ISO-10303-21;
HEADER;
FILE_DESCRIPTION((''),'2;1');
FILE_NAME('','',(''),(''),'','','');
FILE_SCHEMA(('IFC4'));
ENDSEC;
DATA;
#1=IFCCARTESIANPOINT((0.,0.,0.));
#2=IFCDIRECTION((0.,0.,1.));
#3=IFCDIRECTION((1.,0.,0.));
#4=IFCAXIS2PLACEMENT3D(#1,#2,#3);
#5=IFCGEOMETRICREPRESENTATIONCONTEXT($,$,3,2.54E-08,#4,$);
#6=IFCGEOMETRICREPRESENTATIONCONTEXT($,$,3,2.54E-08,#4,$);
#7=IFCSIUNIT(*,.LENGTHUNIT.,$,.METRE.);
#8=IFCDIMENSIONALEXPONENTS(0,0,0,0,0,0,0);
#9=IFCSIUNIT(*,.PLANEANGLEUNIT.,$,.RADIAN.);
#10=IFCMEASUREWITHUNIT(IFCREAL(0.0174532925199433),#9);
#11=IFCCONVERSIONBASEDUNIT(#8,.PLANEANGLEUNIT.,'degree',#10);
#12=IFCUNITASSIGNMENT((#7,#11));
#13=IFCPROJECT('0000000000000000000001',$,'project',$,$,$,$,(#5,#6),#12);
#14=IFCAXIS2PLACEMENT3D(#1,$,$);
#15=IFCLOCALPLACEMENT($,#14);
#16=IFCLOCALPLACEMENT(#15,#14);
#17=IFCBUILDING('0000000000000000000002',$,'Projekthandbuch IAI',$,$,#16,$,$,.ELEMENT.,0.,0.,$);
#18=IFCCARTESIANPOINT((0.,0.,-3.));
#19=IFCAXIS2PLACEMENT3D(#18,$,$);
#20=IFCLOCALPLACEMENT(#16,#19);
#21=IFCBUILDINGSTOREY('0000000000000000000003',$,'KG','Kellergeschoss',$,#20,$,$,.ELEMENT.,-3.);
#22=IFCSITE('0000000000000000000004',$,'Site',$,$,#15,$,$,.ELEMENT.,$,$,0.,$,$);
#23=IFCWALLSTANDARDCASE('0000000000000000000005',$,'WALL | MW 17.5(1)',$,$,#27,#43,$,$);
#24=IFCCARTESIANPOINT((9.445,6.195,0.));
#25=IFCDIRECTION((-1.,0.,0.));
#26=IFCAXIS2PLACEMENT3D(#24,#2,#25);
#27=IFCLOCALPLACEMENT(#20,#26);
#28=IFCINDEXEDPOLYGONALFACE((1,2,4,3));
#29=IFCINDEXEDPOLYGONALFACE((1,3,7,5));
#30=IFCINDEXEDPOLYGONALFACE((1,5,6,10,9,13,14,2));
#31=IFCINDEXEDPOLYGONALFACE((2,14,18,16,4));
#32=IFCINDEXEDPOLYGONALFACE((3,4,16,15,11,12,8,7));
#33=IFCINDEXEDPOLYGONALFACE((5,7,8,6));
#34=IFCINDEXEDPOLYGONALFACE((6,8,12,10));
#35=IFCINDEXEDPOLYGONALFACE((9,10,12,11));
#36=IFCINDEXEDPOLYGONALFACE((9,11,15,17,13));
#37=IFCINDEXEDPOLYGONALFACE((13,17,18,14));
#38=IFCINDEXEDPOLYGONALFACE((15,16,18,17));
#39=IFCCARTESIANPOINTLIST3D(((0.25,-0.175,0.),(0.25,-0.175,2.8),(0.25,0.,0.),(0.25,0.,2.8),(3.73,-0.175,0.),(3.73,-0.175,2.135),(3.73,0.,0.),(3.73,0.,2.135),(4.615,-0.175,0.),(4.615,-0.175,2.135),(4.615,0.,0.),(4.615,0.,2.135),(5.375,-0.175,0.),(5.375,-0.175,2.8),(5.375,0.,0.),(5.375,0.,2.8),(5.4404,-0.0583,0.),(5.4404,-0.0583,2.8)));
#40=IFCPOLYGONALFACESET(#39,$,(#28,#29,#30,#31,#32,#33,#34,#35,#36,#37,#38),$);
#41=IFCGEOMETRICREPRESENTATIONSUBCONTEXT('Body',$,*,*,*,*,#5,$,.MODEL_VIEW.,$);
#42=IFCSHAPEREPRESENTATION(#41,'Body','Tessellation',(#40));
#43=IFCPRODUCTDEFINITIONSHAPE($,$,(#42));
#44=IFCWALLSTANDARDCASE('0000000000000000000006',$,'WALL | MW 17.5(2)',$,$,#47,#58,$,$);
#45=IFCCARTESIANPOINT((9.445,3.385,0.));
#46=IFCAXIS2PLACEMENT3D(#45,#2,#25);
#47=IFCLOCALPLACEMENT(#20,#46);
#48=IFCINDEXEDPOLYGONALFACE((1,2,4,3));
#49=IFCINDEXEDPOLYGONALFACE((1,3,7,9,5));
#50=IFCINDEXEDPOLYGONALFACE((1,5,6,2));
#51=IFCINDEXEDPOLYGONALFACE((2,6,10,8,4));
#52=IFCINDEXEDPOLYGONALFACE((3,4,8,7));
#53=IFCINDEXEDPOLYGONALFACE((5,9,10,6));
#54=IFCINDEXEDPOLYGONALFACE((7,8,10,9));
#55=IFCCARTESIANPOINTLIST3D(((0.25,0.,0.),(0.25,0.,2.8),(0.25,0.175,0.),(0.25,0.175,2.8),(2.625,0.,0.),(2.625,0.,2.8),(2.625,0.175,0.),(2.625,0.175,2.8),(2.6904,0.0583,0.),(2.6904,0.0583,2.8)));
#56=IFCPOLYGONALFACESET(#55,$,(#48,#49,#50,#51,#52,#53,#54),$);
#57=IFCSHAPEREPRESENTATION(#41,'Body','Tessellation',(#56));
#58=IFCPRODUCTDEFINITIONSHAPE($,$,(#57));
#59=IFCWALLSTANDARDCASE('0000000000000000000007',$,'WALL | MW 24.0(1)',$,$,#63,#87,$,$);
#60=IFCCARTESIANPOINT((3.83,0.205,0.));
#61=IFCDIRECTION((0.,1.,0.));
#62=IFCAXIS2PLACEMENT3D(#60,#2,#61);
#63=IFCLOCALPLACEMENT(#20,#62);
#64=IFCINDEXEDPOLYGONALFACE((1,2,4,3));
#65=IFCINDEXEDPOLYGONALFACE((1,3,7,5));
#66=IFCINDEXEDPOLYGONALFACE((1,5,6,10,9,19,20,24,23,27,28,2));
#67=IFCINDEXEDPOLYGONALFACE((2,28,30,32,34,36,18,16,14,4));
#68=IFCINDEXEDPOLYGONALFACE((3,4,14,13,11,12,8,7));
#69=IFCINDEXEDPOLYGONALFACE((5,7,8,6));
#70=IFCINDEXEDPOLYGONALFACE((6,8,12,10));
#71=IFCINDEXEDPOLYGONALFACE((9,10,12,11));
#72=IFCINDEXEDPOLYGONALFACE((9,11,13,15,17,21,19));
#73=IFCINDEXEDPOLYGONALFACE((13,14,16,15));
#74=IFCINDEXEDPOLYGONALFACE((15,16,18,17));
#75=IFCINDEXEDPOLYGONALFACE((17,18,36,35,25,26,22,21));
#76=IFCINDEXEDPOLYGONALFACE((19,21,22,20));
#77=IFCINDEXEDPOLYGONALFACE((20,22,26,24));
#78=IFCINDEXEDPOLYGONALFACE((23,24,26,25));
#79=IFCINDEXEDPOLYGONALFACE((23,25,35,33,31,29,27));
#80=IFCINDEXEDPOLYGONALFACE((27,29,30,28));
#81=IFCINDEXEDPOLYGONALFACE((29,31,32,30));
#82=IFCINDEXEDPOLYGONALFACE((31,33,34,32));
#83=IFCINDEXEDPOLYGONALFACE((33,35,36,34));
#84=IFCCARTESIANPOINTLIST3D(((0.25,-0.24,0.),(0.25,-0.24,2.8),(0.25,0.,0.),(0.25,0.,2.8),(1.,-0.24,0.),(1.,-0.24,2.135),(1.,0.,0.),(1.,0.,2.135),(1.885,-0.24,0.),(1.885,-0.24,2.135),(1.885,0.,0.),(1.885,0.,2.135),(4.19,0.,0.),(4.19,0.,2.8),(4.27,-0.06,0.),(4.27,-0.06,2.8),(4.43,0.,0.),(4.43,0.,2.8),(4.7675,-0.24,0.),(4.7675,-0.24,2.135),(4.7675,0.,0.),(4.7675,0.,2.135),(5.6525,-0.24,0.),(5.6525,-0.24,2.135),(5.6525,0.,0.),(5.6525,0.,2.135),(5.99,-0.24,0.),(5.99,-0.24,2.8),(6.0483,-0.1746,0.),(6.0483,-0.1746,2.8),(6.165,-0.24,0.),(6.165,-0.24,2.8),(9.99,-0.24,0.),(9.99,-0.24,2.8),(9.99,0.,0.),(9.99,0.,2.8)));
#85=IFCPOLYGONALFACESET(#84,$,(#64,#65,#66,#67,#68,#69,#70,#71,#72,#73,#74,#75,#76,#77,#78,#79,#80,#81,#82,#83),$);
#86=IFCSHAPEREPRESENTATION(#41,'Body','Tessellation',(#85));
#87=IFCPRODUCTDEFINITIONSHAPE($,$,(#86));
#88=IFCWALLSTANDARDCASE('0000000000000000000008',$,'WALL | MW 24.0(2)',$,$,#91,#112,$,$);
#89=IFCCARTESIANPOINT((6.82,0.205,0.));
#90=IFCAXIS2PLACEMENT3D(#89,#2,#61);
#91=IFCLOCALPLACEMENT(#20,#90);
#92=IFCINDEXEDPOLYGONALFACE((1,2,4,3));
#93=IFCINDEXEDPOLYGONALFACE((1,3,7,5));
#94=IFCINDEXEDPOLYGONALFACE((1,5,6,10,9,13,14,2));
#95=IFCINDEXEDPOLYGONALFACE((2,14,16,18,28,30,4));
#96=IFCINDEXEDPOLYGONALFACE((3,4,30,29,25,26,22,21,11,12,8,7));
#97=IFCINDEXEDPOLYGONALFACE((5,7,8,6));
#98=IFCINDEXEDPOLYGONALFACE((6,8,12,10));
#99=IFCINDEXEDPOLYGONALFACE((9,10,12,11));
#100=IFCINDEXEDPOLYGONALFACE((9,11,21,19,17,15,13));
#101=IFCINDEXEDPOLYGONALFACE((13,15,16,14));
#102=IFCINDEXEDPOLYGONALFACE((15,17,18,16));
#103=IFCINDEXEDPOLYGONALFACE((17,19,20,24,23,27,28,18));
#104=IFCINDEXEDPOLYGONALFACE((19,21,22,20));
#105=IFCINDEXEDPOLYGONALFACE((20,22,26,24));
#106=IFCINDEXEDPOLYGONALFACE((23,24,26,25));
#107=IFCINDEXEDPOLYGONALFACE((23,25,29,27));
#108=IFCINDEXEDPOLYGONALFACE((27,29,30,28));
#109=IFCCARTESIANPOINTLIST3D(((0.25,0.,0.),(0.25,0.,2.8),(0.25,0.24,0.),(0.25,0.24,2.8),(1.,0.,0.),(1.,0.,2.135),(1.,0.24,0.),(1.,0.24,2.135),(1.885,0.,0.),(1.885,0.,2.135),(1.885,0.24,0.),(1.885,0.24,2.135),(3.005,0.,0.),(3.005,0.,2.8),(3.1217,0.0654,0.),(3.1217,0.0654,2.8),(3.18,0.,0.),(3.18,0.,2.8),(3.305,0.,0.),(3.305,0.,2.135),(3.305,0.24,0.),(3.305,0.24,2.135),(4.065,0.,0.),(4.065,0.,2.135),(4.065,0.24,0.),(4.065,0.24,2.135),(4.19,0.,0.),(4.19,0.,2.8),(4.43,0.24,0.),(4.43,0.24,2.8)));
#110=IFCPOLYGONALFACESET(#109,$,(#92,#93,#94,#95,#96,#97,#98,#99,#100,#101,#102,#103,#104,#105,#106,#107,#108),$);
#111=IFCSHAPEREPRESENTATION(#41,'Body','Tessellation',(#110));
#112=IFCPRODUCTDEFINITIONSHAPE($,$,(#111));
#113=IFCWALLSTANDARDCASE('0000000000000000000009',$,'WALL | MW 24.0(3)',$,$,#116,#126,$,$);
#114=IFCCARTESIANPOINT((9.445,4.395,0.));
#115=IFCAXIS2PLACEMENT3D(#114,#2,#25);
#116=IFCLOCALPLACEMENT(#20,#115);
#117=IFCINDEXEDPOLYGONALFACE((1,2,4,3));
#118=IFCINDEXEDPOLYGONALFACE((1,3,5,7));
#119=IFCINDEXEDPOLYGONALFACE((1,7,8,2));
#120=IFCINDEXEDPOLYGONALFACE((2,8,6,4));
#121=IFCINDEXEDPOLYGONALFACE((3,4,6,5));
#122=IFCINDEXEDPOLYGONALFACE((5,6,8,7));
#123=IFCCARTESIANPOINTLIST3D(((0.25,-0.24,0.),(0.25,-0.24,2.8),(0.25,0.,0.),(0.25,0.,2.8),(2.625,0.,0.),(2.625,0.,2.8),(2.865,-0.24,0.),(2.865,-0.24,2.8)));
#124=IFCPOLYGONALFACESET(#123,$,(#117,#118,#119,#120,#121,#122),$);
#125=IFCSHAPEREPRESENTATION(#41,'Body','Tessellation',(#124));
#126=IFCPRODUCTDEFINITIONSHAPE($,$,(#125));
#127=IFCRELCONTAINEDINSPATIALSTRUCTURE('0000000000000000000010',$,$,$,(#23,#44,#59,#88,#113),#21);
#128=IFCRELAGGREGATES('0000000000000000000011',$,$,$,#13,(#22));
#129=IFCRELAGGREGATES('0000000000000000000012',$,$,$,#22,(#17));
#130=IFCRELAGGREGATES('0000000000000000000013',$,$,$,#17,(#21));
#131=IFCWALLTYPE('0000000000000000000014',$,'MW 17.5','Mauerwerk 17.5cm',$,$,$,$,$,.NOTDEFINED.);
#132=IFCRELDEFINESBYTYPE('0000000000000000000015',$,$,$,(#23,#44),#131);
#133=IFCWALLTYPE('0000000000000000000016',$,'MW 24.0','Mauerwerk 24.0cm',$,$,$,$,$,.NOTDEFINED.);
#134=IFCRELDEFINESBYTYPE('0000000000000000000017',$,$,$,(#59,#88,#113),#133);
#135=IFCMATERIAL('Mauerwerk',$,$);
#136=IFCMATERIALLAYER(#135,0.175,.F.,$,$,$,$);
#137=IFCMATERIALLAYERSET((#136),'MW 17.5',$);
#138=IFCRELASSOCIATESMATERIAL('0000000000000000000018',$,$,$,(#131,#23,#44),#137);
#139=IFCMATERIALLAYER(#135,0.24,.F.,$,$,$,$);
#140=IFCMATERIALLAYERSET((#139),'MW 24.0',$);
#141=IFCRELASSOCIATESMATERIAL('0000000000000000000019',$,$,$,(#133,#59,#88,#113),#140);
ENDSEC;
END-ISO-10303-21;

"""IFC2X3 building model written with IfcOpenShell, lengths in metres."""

from ifc_helpers import new_model, entity, si_unit, converted_unit, frame, origin, origin_with_axes, origin_2d_with_axis, place, context, subcontext, project, spatial, polyline, segment, composite_curve, rectangle, outline, extrude, material, layer, layer_set, layer_usage, type_object, element, save


model = new_model("IFC2X3")

# Units and contexts
context_of_model_1 = context(None, 3, precision=2.54e-08, world=origin_with_axes())
context_of_model_2 = context(None, 3, precision=2.54e-08, world=origin_with_axes())
body_context = subcontext(context_of_model_1, "Body", None, "MODEL_VIEW")
ifc_project = project(units=[si_unit("LENGTHUNIT", "METRE"), converted_unit("PLANEANGLEUNIT", "degree", entity("IfcReal", 0.0174532925199433), si_unit("PLANEANGLEUNIT", "RADIAN"), dimensions=[0, 0, 0, 0, 0, 0, 0])], contexts=[context_of_model_1, context_of_model_2])

# Site, building, storey
site_placement = place(None, origin())
site = spatial("IfcSite", under=ifc_project, at=site_placement, Name="Site", CompositionType="ELEMENT", RefElevation=0.0)
building_placement = place(site_placement, origin())
building = spatial("IfcBuilding", under=site, at=building_placement, Name="Projekthandbuch IAI", CompositionType="ELEMENT", ElevationOfRefHeight=0.0, ElevationOfTerrain=0.0)
storey_placement = place(building_placement, frame((0.0, 0.0, -3.0)))
storey = spatial("IfcBuildingStorey", under=building, at=storey_placement, Name="KG", Description="Kellergeschoss", CompositionType="ELEMENT", Elevation=-3.0)

# Wall, opening
ifc_material_1 = material(Name="Mauerwerk")
ifc_layer_1 = layer(ifc_material_1, 0.175, ventilated=False)
ifc_layer_set_1 = layer_set([ifc_layer_1], Name="MW 17.5")
ifc_layer_usage_1 = layer_usage(ifc_layer_set_1, "AXIS2", "POSITIVE", -0.175)
wall_type_1 = type_object("IfcWallType", Name="MW 17.5", Description="Mauerwerk 17.5cm", PredefinedType="NOTDEFINED", material=ifc_layer_set_1)
wall_1_placement = place(storey_placement, frame((9.445, 6.195, 0.0), z_axis=(0.0, 0.0, 1.0), x_axis=(-1.0, 0.0, 0.0)))
wall_1 = element("IfcWallStandardCase", 1, at=wall_1_placement, inside=storey, type_object=wall_type_1, material=ifc_layer_usage_1, Name="WALL | MW 17.5(1)", context=body_context, shape_type="SweptSolid", held_by="IfcProductRepresentation", body=[
    extrude(outline(composite_curve([segment(polyline([(5.375, -0.175), (5.4404, -0.0583)]), True, "CONTINUOUS"), segment(polyline([(5.4404, -0.0583), (5.375, 0.0)]), True, "CONTINUOUS"), segment(polyline([(5.375, 0.0), (0.25, 0.0)]), True, "CONTINUOUS"), segment(polyline([(0.25, 0.0), (0.25, -0.175)]), True, "CONTINUOUS"), segment(polyline([(0.25, -0.175), (5.375, -0.175)]), True, "CONTINUOUS")], self_intersect=False)), origin(), (0.0, 0.0, 1.0), 2.8),
])
opening_1_placement = place(wall_1_placement, frame((3.73, -0.0875, 0.0)))
element("IfcOpeningElement", 2, at=opening_1_placement, cuts=wall_1, context=body_context, shape_type="SweptSolid", held_by="IfcProductRepresentation", body=[
    extrude(rectangle(XDim=0.885, YDim=2.135, at=origin_2d_with_axis()), frame((0.4425, 0.0875, 1.0675), z_axis=(0.0, -1.0, 0.0), x_axis=(1.0, 0.0, 0.0)), (0.0, 0.0, 1.0), 0.175),
])

# Wall
ifc_layer_usage_2 = layer_usage(ifc_layer_set_1, "AXIS2", "POSITIVE", 0.0)
wall_2_placement = place(storey_placement, frame((9.445, 3.385, 0.0), z_axis=(0.0, 0.0, 1.0), x_axis=(-1.0, 0.0, 0.0)))
element("IfcWallStandardCase", 3, at=wall_2_placement, inside=storey, type_object=wall_type_1, material=ifc_layer_usage_2, Name="WALL | MW 17.5(2)", context=body_context, shape_type="SweptSolid", held_by="IfcProductRepresentation", body=[
    extrude(outline(composite_curve([segment(polyline([(2.625, 0.0), (2.6904, 0.0583)]), True, "CONTINUOUS"), segment(polyline([(2.6904, 0.0583), (2.625, 0.175)]), True, "CONTINUOUS"), segment(polyline([(2.625, 0.175), (0.25, 0.175)]), True, "CONTINUOUS"), segment(polyline([(0.25, 0.175), (0.25, 0.0)]), True, "CONTINUOUS"), segment(polyline([(0.25, 0.0), (2.625, 0.0)]), True, "CONTINUOUS")], self_intersect=False)), origin(), (0.0, 0.0, 1.0), 2.8),
])

# Walls, openings
ifc_layer_2 = layer(ifc_material_1, 0.24, ventilated=False)
ifc_layer_set_2 = layer_set([ifc_layer_2], Name="MW 24.0")
ifc_layer_usage_3 = layer_usage(ifc_layer_set_2, "AXIS2", "POSITIVE", -0.24)
wall_type_2 = type_object("IfcWallType", Name="MW 24.0", Description="Mauerwerk 24.0cm", PredefinedType="NOTDEFINED", material=ifc_layer_set_2)
wall_3_placement = place(storey_placement, frame((3.83, 0.205, 0.0), z_axis=(0.0, 0.0, 1.0), x_axis=(0.0, 1.0, 0.0)))
wall_3 = element("IfcWallStandardCase", 4, at=wall_3_placement, inside=storey, type_object=wall_type_2, material=ifc_layer_usage_3, Name="WALL | MW 24.0(1)", context=body_context, shape_type="SweptSolid", held_by="IfcProductRepresentation", body=[
    extrude(outline(composite_curve([segment(polyline([(6.0483, -0.1746), (6.165, -0.24)]), True, "CONTINUOUS"), segment(polyline([(6.165, -0.24), (9.99, -0.24)]), True, "CONTINUOUS"), segment(polyline([(9.99, -0.24), (9.99, 0.0)]), True, "CONTINUOUS"), segment(polyline([(9.99, 0.0), (5.99, 0.0)]), True, "CONTINUOUS"), segment(polyline([(5.99, 0.0), (4.43, 0.0)]), True, "CONTINUOUS"), segment(polyline([(4.43, 0.0), (4.27, -0.06)]), True, "CONTINUOUS"), segment(polyline([(4.27, -0.06), (4.19, 0.0)]), True, "CONTINUOUS"), segment(polyline([(4.19, 0.0), (0.25, 0.0)]), True, "CONTINUOUS"), segment(polyline([(0.25, 0.0), (0.25, -0.24)]), True, "CONTINUOUS"), segment(polyline([(0.25, -0.24), (4.19, -0.24)]), True, "CONTINUOUS"), segment(polyline([(4.19, -0.24), (5.99, -0.24)]), True, "CONTINUOUS"), segment(polyline([(5.99, -0.24), (6.0483, -0.1746)]), True, "CONTINUOUS")], self_intersect=False)), origin(), (0.0, 0.0, 1.0), 2.8),
])
opening_2_placement = place(wall_3_placement, frame((1.0, -0.12, 0.0)))
element("IfcOpeningElement", 5, at=opening_2_placement, cuts=wall_3, context=body_context, shape_type="SweptSolid", held_by="IfcProductRepresentation", body=[
    extrude(rectangle(XDim=0.885, YDim=2.135, at=origin_2d_with_axis()), frame((0.4425, 0.12, 1.0675), z_axis=(0.0, -1.0, 0.0), x_axis=(1.0, 0.0, 0.0)), (0.0, 0.0, 1.0), 0.24),
])
opening_3_placement = place(wall_3_placement, frame((4.7675, -0.12, 0.0)))
element("IfcOpeningElement", 6, at=opening_3_placement, cuts=wall_3, context=body_context, shape_type="SweptSolid", held_by="IfcProductRepresentation", body=[
    extrude(rectangle(XDim=0.885, YDim=2.135, at=origin_2d_with_axis()), frame((0.4425, 0.12, 1.0675), z_axis=(0.0, -1.0, 0.0), x_axis=(1.0, 0.0, 0.0)), (0.0, 0.0, 1.0), 0.24),
])
ifc_layer_usage_4 = layer_usage(ifc_layer_set_2, "AXIS2", "POSITIVE", 0.0)
wall_4_placement = place(storey_placement, frame((6.82, 0.205, 0.0), z_axis=(0.0, 0.0, 1.0), x_axis=(0.0, 1.0, 0.0)))
wall_4 = element("IfcWallStandardCase", 7, at=wall_4_placement, inside=storey, type_object=wall_type_2, material=ifc_layer_usage_4, Name="WALL | MW 24.0(2)", context=body_context, shape_type="SweptSolid", held_by="IfcProductRepresentation", body=[
    extrude(outline(composite_curve([segment(polyline([(3.005, 0.0), (3.1217, 0.0654)]), True, "CONTINUOUS"), segment(polyline([(3.1217, 0.0654), (3.18, 0.0)]), True, "CONTINUOUS"), segment(polyline([(3.18, 0.0), (4.19, 0.0)]), True, "CONTINUOUS"), segment(polyline([(4.19, 0.0), (4.43, 0.24)]), True, "CONTINUOUS"), segment(polyline([(4.43, 0.24), (3.18, 0.24)]), True, "CONTINUOUS"), segment(polyline([(3.18, 0.24), (0.25, 0.24)]), True, "CONTINUOUS"), segment(polyline([(0.25, 0.24), (0.25, 0.0)]), True, "CONTINUOUS"), segment(polyline([(0.25, 0.0), (3.005, 0.0)]), True, "CONTINUOUS")], self_intersect=False)), origin(), (0.0, 0.0, 1.0), 2.8),
])
opening_4_placement = place(wall_4_placement, frame((1.0, 0.12, 0.0)))
element("IfcOpeningElement", 8, at=opening_4_placement, cuts=wall_4, context=body_context, shape_type="SweptSolid", held_by="IfcProductRepresentation", body=[
    extrude(rectangle(XDim=0.885, YDim=2.135, at=origin_2d_with_axis()), frame((0.4425, 0.12, 1.0675), z_axis=(0.0, -1.0, 0.0), x_axis=(1.0, 0.0, 0.0)), (0.0, 0.0, 1.0), 0.24),
])
opening_5_placement = place(wall_4_placement, frame((3.305, 0.12, 0.0)))
element("IfcOpeningElement", 9, at=opening_5_placement, cuts=wall_4, context=body_context, shape_type="SweptSolid", held_by="IfcProductRepresentation", body=[
    extrude(rectangle(XDim=0.76, YDim=2.135, at=origin_2d_with_axis()), frame((0.38, 0.12, 1.0675), z_axis=(0.0, -1.0, 0.0), x_axis=(1.0, 0.0, 0.0)), (0.0, 0.0, 1.0), 0.24),
])

# Wall
ifc_layer_usage_5 = layer_usage(ifc_layer_set_2, "AXIS2", "POSITIVE", -0.24)
wall_5_placement = place(storey_placement, frame((9.445, 4.395, 0.0), z_axis=(0.0, 0.0, 1.0), x_axis=(-1.0, 0.0, 0.0)))
element("IfcWallStandardCase", 10, at=wall_5_placement, inside=storey, type_object=wall_type_2, material=ifc_layer_usage_5, Name="WALL | MW 24.0(3)", context=body_context, shape_type="SweptSolid", held_by="IfcProductRepresentation", body=[
    extrude(outline(composite_curve([segment(polyline([(2.865, -0.24), (2.625, 0.0)]), True, "CONTINUOUS"), segment(polyline([(2.625, 0.0), (0.25, 0.0)]), True, "CONTINUOUS"), segment(polyline([(0.25, 0.0), (0.25, -0.24)]), True, "CONTINUOUS"), segment(polyline([(0.25, -0.24), (2.865, -0.24)]), True, "CONTINUOUS")], self_intersect=False)), origin(), (0.0, 0.0, 1.0), 2.8),
])

save(model, "model.ifc")
